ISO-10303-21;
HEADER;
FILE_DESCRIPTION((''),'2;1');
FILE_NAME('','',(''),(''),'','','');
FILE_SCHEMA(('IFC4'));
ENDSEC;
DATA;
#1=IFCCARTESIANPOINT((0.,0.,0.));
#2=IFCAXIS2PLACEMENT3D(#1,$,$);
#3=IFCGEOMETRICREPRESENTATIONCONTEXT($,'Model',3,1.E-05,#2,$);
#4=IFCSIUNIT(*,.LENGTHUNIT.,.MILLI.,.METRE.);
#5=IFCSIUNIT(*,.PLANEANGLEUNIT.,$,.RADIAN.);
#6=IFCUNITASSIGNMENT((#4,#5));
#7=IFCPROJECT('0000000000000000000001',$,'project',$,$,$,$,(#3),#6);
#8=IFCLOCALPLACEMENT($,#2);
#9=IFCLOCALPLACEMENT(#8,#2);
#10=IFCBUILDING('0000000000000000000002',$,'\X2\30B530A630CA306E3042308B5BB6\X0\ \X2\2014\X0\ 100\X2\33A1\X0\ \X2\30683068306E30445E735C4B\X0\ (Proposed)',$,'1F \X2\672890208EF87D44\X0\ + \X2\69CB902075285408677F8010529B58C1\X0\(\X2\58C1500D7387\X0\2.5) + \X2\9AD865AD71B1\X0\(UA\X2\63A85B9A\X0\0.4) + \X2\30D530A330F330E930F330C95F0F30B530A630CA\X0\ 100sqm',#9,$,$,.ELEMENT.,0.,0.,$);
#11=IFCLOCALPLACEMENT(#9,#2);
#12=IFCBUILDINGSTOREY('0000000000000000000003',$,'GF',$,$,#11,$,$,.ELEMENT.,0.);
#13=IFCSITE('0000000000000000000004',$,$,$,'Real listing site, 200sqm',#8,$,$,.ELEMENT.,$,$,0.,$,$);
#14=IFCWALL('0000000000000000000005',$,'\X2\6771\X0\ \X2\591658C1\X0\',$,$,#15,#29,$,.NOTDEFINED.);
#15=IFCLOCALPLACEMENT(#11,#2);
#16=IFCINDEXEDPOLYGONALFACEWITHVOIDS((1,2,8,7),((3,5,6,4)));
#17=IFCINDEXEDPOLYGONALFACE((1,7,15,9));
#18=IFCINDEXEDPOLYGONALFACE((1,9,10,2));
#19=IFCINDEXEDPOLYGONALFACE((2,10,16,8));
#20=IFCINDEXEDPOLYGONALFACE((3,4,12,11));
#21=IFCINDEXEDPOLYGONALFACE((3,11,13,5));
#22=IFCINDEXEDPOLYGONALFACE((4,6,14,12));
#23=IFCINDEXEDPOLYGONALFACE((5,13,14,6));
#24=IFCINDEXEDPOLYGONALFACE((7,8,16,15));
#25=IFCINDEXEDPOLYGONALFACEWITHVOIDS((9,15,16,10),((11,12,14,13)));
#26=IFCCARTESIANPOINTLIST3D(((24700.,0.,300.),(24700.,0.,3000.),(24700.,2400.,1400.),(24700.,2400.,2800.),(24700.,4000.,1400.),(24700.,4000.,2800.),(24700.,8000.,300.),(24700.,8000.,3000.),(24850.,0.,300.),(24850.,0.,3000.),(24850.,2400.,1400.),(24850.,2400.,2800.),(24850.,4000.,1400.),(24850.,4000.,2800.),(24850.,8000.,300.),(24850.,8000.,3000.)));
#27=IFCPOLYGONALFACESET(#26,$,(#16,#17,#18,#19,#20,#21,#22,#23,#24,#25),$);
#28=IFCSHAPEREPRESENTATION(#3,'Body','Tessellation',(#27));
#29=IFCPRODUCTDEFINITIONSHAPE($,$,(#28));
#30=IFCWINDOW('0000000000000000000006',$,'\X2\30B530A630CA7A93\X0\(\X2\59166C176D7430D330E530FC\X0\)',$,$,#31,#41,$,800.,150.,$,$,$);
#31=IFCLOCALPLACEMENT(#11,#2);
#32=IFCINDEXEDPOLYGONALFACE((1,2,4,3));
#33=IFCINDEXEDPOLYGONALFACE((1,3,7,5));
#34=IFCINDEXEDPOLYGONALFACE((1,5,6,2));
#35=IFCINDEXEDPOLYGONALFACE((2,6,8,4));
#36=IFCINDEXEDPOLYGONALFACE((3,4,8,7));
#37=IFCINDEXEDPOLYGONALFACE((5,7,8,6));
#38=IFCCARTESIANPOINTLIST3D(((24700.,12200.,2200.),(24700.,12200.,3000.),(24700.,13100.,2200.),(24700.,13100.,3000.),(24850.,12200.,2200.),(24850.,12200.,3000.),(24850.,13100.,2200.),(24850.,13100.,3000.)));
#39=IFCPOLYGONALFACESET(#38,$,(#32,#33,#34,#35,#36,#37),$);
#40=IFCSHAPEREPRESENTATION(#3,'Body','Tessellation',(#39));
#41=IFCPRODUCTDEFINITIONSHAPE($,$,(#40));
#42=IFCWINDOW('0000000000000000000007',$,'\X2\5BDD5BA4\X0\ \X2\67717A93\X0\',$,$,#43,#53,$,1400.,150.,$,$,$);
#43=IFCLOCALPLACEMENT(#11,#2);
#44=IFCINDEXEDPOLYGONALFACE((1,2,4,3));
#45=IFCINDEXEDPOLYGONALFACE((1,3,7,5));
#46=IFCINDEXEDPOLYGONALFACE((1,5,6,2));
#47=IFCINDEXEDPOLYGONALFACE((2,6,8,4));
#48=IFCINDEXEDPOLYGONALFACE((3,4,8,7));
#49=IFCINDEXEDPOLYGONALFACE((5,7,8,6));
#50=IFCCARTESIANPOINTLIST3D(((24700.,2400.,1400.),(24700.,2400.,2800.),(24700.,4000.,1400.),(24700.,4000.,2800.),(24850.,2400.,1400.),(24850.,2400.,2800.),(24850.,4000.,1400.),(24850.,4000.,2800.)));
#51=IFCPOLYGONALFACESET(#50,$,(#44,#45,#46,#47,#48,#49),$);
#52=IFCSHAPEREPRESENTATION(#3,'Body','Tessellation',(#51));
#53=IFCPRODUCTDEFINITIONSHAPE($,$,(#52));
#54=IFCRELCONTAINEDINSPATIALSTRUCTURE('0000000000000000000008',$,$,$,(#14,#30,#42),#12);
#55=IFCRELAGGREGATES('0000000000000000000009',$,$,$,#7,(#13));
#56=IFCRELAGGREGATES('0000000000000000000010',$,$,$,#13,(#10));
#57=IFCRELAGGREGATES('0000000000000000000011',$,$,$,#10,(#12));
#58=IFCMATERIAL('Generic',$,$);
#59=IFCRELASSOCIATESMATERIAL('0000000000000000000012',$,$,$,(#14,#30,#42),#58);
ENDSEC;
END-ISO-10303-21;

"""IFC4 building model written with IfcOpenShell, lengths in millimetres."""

from ifc_helpers import new_model, si_unit, frame, frame_2d, origin, place, context, project, spatial, rectangle, extrude, material, element, fill, save


model = new_model("IFC4")

# Units and contexts
model_context = context("Model", 3, precision=1e-05, world=origin())
ifc_project = project(units=[si_unit("LENGTHUNIT", "METRE", prefix="MILLI"), si_unit("PLANEANGLEUNIT", "RADIAN")], contexts=[model_context])

# Site, building, storey
site_placement = place(None, origin())
site = spatial("IfcSite", under=ifc_project, at=site_placement, ObjectType="Real listing site, 200sqm", CompositionType="ELEMENT", RefElevation=0.0)
building_placement = place(site_placement, origin())
building = spatial("IfcBuilding", under=site, at=building_placement, Name="サウナのある家 — 100㎡ ととのい平屋 (Proposed)", ObjectType="1F 木造軸組 + 構造用合板耐力壁(壁倍率2.5) + 高断熱(UA推定0.4) + フィンランド式サウナ 100sqm", CompositionType="ELEMENT", ElevationOfRefHeight=0.0, ElevationOfTerrain=0.0)
storey_placement = place(building_placement, origin())
storey = spatial("IfcBuildingStorey", under=building, at=storey_placement, Name="GF", CompositionType="ELEMENT", Elevation=0.0)

# Wall, openings, windows
ifc_material = material(Name="Generic")
wall_1_placement = place(storey_placement, frame((12350.0, 0.0, 150.0)))
wall_1 = element("IfcWall", 1, at=wall_1_placement, inside=storey, material=ifc_material, Name="東 外壁", PredefinedType="NOTDEFINED", context=model_context, shape_type="SweptSolid", body=[
    extrude(rectangle(XDim=150.0, YDim=8000.0, at=frame_2d((75.0, 4000.0))), frame((12350.0, 0.0, 150.0)), (0.0, 0.0, 1.0), 2700.0),
])
opening_1_placement = place(storey_placement, frame((12350.0, 6100.0, 1100.0)))
opening_1 = element("IfcOpeningElement", 2, at=opening_1_placement, cuts=wall_1, PredefinedType="NOTDEFINED", context=model_context, shape_type="SweptSolid", body=[
    extrude(rectangle(XDim=150.0, YDim=900.0, at=frame_2d((75.0, 450.0))), frame((12350.0, 6100.0, 1100.0)), (0.0, 0.0, 1.0), 800.0),
])
opening_2_placement = place(storey_placement, frame((12350.0, 1200.0, 700.0)))
opening_2 = element("IfcOpeningElement", 3, at=opening_2_placement, cuts=wall_1, PredefinedType="NOTDEFINED", context=model_context, shape_type="SweptSolid", body=[
    extrude(rectangle(XDim=150.0, YDim=1600.0, at=frame_2d((75.0, 800.0))), frame((12350.0, 1200.0, 700.0)), (0.0, 0.0, 1.0), 1400.0),
])
window_1_placement = place(storey_placement, frame((12350.0, 6100.0, 1100.0)))
window_1 = element("IfcWindow", 4, at=window_1_placement, inside=storey, material=ifc_material, Name="サウナ窓(外気浴ビュー)", OverallHeight=800.0, OverallWidth=150.0, context=model_context, shape_type="SweptSolid", body=[
    extrude(rectangle(XDim=150.0, YDim=900.0, at=frame_2d((75.0, 450.0))), frame((12350.0, 6100.0, 1100.0)), (0.0, 0.0, 1.0), 800.0),
])
fill(opening_1, window_1)
window_2_placement = place(storey_placement, frame((12350.0, 1200.0, 700.0)))
window_2 = element("IfcWindow", 5, at=window_2_placement, inside=storey, material=ifc_material, Name="寝室 東窓", OverallHeight=1400.0, OverallWidth=150.0, context=model_context, shape_type="SweptSolid", body=[
    extrude(rectangle(XDim=150.0, YDim=1600.0, at=frame_2d((75.0, 800.0))), frame((12350.0, 1200.0, 700.0)), (0.0, 0.0, 1.0), 1400.0),
])
fill(opening_2, window_2)

save(model, "model.ifc")
